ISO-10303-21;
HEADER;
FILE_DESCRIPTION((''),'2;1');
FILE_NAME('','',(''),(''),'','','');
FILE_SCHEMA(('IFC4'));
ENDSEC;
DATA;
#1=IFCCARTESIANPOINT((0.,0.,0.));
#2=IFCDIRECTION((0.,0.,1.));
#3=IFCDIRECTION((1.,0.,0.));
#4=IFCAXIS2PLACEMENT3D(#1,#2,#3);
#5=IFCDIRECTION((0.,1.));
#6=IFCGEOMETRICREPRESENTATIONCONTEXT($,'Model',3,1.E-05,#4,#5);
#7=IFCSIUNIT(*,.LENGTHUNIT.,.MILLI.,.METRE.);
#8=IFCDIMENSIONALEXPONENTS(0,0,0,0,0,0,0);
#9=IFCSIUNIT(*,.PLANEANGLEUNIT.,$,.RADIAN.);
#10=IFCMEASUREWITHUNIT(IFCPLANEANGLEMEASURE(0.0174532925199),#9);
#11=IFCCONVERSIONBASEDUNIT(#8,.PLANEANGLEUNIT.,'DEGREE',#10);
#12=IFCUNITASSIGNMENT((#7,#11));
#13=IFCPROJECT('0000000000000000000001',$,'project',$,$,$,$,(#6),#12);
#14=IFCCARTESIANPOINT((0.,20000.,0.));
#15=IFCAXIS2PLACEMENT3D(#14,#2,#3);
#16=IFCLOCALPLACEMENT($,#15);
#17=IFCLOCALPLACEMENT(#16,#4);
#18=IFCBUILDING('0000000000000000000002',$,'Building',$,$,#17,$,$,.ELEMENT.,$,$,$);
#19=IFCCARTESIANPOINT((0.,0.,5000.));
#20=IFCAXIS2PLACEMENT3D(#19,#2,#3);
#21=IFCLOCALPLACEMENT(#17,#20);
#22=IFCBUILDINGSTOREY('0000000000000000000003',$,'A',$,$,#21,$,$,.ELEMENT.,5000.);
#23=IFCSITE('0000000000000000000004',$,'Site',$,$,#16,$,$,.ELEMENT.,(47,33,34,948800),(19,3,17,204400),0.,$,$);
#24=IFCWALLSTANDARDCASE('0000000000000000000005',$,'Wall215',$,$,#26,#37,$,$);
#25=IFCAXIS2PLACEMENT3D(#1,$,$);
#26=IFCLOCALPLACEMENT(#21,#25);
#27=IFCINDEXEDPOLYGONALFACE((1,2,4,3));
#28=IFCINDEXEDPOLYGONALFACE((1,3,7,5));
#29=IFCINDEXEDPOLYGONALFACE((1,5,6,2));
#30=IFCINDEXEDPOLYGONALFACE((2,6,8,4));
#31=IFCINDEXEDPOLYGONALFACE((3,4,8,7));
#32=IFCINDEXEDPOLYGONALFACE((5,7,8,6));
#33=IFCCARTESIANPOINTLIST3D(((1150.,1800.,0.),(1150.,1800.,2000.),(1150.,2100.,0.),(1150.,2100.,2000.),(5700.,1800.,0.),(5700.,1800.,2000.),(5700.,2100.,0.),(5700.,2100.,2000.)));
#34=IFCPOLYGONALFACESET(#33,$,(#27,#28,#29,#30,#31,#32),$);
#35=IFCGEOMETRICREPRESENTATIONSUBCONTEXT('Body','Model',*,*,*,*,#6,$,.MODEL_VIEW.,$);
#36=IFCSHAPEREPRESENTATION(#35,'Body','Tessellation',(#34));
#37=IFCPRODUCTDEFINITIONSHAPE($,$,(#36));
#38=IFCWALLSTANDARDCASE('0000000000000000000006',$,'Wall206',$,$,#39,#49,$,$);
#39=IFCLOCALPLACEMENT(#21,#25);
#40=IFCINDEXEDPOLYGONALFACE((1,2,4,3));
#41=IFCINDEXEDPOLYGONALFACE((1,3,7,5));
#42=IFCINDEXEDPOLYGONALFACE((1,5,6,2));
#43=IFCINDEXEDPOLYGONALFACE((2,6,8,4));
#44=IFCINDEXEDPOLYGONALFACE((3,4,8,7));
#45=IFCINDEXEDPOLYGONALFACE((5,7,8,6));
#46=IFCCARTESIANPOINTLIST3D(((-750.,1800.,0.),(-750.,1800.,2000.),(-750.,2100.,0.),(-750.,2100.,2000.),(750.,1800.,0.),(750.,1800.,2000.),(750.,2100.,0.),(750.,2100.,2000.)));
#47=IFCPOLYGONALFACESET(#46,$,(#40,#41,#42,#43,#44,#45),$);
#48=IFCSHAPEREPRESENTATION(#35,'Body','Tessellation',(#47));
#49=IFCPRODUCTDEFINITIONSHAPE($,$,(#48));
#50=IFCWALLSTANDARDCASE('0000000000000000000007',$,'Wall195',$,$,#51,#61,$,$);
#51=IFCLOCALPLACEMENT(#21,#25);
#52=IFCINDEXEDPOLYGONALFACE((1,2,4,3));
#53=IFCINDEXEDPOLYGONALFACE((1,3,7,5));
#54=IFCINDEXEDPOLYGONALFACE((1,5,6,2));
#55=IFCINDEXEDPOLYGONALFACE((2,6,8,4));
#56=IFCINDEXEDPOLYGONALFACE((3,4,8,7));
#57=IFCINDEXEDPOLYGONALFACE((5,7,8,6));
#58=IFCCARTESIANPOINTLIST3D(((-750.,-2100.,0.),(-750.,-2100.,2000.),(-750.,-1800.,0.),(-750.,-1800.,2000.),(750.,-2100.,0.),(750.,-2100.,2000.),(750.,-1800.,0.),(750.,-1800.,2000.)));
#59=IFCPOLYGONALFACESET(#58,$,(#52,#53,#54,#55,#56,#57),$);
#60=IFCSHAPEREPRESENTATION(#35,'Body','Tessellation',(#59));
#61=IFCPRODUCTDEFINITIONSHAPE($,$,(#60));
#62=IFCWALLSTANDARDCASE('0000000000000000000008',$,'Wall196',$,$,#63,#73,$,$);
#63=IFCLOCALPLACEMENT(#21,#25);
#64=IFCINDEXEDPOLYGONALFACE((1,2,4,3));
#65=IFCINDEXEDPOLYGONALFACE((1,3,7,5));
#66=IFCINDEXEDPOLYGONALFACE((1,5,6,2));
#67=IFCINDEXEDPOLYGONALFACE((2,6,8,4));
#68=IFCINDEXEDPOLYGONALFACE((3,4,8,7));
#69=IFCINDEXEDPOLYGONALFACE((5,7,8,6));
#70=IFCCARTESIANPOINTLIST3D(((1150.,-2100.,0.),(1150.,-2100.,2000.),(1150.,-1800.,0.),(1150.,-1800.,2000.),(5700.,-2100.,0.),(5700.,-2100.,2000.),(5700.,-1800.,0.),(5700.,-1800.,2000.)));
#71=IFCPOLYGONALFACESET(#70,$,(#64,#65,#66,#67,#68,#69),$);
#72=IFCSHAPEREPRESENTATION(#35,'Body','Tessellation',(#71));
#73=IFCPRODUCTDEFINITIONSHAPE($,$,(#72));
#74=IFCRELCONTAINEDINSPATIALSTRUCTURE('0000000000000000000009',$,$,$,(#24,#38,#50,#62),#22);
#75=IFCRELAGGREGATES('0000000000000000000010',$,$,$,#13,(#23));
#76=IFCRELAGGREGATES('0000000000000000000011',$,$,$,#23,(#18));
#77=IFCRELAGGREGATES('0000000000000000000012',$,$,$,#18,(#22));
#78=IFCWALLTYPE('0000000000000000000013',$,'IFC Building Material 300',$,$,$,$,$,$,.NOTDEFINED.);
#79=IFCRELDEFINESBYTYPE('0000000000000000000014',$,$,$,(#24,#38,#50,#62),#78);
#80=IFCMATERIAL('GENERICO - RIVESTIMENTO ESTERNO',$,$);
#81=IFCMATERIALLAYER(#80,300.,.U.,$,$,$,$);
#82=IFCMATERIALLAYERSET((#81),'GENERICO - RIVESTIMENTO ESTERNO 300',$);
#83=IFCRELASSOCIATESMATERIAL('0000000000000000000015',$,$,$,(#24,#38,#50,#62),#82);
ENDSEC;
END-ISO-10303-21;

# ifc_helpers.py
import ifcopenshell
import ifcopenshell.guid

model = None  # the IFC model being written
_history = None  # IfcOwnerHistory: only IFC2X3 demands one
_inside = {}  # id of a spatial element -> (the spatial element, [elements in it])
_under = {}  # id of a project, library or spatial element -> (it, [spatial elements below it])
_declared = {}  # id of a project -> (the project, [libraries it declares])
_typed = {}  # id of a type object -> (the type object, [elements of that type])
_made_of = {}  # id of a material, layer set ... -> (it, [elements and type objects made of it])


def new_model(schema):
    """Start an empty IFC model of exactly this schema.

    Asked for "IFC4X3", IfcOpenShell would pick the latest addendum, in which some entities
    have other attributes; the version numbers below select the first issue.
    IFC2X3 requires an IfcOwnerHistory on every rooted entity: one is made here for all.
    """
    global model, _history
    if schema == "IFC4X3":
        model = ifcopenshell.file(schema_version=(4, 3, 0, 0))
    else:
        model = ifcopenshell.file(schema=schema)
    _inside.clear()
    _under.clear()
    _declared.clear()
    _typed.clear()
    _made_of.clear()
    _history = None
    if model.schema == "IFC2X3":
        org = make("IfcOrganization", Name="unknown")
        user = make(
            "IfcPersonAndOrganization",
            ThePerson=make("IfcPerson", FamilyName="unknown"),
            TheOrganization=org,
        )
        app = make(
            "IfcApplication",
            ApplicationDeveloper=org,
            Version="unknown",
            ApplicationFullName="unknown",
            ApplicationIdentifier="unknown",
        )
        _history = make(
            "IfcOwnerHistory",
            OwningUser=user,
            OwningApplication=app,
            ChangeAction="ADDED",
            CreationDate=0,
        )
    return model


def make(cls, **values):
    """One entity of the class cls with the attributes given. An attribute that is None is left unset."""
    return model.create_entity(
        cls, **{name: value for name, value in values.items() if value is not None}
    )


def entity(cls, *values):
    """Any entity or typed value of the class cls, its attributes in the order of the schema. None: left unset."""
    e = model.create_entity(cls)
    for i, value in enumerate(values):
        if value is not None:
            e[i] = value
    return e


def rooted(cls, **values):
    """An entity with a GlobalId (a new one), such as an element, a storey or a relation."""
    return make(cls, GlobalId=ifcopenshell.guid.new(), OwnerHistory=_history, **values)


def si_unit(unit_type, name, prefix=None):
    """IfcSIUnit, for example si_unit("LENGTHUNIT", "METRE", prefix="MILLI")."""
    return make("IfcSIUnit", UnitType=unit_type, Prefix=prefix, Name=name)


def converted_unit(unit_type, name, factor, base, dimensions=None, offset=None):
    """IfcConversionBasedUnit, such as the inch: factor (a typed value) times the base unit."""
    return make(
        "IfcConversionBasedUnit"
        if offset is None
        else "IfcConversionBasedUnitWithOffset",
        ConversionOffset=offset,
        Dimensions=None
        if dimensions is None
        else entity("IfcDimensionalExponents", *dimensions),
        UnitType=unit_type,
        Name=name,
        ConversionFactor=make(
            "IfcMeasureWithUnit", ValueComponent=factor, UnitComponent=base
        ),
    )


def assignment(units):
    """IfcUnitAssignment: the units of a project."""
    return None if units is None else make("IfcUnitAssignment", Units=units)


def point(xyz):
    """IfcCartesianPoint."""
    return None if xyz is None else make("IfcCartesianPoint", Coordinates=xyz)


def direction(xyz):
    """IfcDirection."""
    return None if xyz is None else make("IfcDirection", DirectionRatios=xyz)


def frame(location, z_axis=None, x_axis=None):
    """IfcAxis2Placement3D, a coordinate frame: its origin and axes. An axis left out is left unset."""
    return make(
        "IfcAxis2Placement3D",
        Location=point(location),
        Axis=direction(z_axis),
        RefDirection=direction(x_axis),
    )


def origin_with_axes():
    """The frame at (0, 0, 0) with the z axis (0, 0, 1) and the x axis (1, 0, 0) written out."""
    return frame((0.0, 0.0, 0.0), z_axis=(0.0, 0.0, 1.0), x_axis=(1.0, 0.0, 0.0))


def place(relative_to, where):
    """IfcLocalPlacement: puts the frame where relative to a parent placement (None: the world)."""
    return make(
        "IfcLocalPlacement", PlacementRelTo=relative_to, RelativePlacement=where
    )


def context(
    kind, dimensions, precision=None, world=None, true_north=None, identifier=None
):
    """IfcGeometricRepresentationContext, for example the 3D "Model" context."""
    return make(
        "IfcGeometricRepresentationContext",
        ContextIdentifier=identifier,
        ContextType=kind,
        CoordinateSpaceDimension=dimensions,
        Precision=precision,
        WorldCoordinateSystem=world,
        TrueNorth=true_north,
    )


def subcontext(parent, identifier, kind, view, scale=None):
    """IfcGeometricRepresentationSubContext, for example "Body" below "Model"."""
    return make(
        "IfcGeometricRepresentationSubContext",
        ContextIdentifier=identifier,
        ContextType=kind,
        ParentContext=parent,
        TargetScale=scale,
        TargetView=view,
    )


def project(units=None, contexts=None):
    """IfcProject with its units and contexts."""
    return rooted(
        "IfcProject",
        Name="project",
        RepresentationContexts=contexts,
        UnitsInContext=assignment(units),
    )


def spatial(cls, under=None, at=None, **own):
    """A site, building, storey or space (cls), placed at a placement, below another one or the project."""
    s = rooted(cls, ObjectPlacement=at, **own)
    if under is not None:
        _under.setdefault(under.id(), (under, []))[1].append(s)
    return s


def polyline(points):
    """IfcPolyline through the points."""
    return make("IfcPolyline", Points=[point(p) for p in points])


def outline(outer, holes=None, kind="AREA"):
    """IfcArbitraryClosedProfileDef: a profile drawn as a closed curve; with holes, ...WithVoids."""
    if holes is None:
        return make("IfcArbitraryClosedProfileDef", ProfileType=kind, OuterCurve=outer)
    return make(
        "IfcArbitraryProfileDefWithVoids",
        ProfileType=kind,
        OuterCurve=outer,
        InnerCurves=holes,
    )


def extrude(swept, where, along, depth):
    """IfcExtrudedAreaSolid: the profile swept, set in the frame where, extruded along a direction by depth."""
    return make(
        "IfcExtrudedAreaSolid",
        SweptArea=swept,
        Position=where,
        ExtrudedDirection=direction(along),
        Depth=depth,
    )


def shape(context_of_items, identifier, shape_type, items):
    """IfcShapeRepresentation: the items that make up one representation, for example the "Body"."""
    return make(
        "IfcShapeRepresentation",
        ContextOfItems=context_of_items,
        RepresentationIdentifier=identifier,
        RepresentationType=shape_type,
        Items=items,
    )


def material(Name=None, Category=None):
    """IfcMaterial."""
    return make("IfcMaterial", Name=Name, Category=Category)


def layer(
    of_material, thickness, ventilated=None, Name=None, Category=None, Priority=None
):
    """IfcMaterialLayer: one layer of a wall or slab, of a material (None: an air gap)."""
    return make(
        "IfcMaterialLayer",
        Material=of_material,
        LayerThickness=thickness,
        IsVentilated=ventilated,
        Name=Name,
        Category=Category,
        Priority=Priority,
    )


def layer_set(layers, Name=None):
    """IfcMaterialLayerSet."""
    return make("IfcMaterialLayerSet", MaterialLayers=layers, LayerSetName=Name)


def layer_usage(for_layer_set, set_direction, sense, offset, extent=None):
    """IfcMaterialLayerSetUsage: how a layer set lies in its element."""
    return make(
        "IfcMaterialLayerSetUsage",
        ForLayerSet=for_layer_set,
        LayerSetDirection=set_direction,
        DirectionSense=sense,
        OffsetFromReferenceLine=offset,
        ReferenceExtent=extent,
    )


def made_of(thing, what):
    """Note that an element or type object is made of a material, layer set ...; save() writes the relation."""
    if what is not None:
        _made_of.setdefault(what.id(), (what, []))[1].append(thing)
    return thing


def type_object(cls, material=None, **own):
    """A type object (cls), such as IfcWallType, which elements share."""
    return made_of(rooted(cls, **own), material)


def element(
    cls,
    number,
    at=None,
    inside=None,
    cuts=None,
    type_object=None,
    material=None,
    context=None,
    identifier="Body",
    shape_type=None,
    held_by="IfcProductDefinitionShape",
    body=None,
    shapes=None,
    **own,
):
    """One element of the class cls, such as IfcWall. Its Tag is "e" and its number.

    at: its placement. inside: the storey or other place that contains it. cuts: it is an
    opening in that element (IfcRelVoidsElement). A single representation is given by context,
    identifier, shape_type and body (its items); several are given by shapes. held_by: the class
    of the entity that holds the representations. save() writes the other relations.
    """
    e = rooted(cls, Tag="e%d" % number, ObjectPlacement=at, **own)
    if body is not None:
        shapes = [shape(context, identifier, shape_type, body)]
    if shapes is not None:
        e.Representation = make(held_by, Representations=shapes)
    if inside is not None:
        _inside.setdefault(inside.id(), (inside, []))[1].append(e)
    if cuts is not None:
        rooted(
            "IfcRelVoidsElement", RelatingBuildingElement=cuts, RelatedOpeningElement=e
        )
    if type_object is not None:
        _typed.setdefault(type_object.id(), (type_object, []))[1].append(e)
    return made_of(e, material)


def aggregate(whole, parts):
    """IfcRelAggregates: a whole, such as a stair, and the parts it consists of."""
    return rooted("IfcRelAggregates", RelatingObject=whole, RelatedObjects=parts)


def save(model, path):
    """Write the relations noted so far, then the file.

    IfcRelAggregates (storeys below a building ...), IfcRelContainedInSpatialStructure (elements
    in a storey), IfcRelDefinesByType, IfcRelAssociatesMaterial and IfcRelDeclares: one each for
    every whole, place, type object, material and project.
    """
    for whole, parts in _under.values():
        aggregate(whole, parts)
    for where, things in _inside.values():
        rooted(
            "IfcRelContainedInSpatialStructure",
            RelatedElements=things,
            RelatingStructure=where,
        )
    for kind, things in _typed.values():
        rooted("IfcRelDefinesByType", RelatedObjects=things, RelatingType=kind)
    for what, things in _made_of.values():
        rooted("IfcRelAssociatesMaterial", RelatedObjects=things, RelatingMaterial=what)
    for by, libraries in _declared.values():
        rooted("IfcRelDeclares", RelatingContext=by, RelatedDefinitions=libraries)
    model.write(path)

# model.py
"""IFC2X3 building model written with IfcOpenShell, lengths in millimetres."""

from ifc_helpers import new_model, entity, si_unit, converted_unit, direction, frame, origin_with_axes, place, context, subcontext, project, spatial, polyline, outline, extrude, material, layer, layer_set, layer_usage, type_object, element, save


model = new_model("IFC2X3")

# Units and contexts
model_context = context("Model", 3, precision=1e-05, world=origin_with_axes(), true_north=direction((0.0, 1.0)))
body_context = subcontext(model_context, "Body", "Model", "MODEL_VIEW")
ifc_project = project(units=[si_unit("LENGTHUNIT", "METRE", prefix="MILLI"), converted_unit("PLANEANGLEUNIT", "DEGREE", entity("IfcPlaneAngleMeasure", 0.0174532925199), si_unit("PLANEANGLEUNIT", "RADIAN"), dimensions=[0, 0, 0, 0, 0, 0, 0])], contexts=[model_context])

# Site, building, storey
site_placement = place(None, frame((0.0, 20000.0, 0.0), z_axis=(0.0, 0.0, 1.0), x_axis=(1.0, 0.0, 0.0)))
site = spatial("IfcSite", under=ifc_project, at=site_placement, Name="Site", CompositionType="ELEMENT", RefLatitude=(47, 33, 34, 948800), RefLongitude=(19, 3, 17, 204400), RefElevation=0.0)
building_placement = place(site_placement, origin_with_axes())
building = spatial("IfcBuilding", under=site, at=building_placement, Name="Building", CompositionType="ELEMENT")
storey_placement = place(building_placement, frame((0.0, 0.0, 5000.0), z_axis=(0.0, 0.0, 1.0), x_axis=(1.0, 0.0, 0.0)))
storey = spatial("IfcBuildingStorey", under=building, at=storey_placement, Name="A", CompositionType="ELEMENT", Elevation=5000.0)

# Shared definitions
ifc_material_1 = material(Name="GENERICO - RIVESTIMENTO ESTERNO")

# Walls
ifc_layer_1 = layer(ifc_material_1, 300.0, ventilated="UNKNOWN")
ifc_layer_set_1 = layer_set([ifc_layer_1], Name="GENERICO - RIVESTIMENTO ESTERNO 300")
ifc_layer_usage_1 = layer_usage(ifc_layer_set_1, "AXIS2", "POSITIVE", -300.0)
wall_type_1 = type_object("IfcWallType", Name="IFC Building Material 300", PredefinedType="NOTDEFINED")
wall_1_placement = place(storey_placement, frame((5700.0, 1800.0, 0.0), z_axis=(0.0, 0.0, 1.0), x_axis=(-1.0, 0.0, 0.0)))
element("IfcWallStandardCase", 1, at=wall_1_placement, inside=storey, type_object=wall_type_1, material=ifc_layer_usage_1, Name="Wall215", context=body_context, shape_type="SweptSolid", body=[
    extrude(outline(polyline([(0.0, -300.0), (4550.0, -300.0), (4550.0, 0.0), (0.0, 0.0), (0.0, -300.0)])), origin_with_axes(), (0.0, 0.0, 1.0), 2000.0),
])
ifc_layer_usage_2 = layer_usage(ifc_layer_set_1, "AXIS2", "POSITIVE", 0.0)
wall_2_placement = place(storey_placement, frame((-750.0, 1800.0, 0.0), z_axis=(0.0, 0.0, 1.0), x_axis=(1.0, 0.0, 0.0)))
element("IfcWallStandardCase", 2, at=wall_2_placement, inside=storey, type_object=wall_type_1, material=ifc_layer_usage_2, Name="Wall206", context=body_context, shape_type="SweptSolid", body=[
    extrude(outline(polyline([(0.0, 0.0), (1500.0, 0.0), (1500.0, 300.0), (0.0, 300.0), (0.0, 0.0)])), origin_with_axes(), (0.0, 0.0, 1.0), 2000.0),
])
ifc_layer_usage_3 = layer_usage(ifc_layer_set_1, "AXIS2", "POSITIVE", -300.0)
wall_3_placement = place(storey_placement, frame((-750.0, -1800.0, 0.0), z_axis=(0.0, 0.0, 1.0), x_axis=(1.0, 0.0, 0.0)))
element("IfcWallStandardCase", 3, at=wall_3_placement, inside=storey, type_object=wall_type_1, material=ifc_layer_usage_3, Name="Wall195", context=body_context, shape_type="SweptSolid", body=[
    extrude(outline(polyline([(0.0, -300.0), (1500.0, -300.0), (1500.0, 0.0), (0.0, 0.0), (0.0, -300.0)])), origin_with_axes(), (0.0, 0.0, 1.0), 2000.0),
])
ifc_layer_usage_4 = layer_usage(ifc_layer_set_1, "AXIS2", "POSITIVE", 0.0)
wall_4_placement = place(storey_placement, frame((5700.0, -1800.0, 0.0), z_axis=(0.0, 0.0, 1.0), x_axis=(-1.0, 0.0, 0.0)))
element("IfcWallStandardCase", 4, at=wall_4_placement, inside=storey, type_object=wall_type_1, material=ifc_layer_usage_4, Name="Wall196", context=body_context, shape_type="SweptSolid", body=[
    extrude(outline(polyline([(0.0, 0.0), (4550.0, 0.0), (4550.0, 300.0), (0.0, 300.0), (0.0, 0.0)])), origin_with_axes(), (0.0, 0.0, 1.0), 2000.0),
])

save(model, "model.ifc")
